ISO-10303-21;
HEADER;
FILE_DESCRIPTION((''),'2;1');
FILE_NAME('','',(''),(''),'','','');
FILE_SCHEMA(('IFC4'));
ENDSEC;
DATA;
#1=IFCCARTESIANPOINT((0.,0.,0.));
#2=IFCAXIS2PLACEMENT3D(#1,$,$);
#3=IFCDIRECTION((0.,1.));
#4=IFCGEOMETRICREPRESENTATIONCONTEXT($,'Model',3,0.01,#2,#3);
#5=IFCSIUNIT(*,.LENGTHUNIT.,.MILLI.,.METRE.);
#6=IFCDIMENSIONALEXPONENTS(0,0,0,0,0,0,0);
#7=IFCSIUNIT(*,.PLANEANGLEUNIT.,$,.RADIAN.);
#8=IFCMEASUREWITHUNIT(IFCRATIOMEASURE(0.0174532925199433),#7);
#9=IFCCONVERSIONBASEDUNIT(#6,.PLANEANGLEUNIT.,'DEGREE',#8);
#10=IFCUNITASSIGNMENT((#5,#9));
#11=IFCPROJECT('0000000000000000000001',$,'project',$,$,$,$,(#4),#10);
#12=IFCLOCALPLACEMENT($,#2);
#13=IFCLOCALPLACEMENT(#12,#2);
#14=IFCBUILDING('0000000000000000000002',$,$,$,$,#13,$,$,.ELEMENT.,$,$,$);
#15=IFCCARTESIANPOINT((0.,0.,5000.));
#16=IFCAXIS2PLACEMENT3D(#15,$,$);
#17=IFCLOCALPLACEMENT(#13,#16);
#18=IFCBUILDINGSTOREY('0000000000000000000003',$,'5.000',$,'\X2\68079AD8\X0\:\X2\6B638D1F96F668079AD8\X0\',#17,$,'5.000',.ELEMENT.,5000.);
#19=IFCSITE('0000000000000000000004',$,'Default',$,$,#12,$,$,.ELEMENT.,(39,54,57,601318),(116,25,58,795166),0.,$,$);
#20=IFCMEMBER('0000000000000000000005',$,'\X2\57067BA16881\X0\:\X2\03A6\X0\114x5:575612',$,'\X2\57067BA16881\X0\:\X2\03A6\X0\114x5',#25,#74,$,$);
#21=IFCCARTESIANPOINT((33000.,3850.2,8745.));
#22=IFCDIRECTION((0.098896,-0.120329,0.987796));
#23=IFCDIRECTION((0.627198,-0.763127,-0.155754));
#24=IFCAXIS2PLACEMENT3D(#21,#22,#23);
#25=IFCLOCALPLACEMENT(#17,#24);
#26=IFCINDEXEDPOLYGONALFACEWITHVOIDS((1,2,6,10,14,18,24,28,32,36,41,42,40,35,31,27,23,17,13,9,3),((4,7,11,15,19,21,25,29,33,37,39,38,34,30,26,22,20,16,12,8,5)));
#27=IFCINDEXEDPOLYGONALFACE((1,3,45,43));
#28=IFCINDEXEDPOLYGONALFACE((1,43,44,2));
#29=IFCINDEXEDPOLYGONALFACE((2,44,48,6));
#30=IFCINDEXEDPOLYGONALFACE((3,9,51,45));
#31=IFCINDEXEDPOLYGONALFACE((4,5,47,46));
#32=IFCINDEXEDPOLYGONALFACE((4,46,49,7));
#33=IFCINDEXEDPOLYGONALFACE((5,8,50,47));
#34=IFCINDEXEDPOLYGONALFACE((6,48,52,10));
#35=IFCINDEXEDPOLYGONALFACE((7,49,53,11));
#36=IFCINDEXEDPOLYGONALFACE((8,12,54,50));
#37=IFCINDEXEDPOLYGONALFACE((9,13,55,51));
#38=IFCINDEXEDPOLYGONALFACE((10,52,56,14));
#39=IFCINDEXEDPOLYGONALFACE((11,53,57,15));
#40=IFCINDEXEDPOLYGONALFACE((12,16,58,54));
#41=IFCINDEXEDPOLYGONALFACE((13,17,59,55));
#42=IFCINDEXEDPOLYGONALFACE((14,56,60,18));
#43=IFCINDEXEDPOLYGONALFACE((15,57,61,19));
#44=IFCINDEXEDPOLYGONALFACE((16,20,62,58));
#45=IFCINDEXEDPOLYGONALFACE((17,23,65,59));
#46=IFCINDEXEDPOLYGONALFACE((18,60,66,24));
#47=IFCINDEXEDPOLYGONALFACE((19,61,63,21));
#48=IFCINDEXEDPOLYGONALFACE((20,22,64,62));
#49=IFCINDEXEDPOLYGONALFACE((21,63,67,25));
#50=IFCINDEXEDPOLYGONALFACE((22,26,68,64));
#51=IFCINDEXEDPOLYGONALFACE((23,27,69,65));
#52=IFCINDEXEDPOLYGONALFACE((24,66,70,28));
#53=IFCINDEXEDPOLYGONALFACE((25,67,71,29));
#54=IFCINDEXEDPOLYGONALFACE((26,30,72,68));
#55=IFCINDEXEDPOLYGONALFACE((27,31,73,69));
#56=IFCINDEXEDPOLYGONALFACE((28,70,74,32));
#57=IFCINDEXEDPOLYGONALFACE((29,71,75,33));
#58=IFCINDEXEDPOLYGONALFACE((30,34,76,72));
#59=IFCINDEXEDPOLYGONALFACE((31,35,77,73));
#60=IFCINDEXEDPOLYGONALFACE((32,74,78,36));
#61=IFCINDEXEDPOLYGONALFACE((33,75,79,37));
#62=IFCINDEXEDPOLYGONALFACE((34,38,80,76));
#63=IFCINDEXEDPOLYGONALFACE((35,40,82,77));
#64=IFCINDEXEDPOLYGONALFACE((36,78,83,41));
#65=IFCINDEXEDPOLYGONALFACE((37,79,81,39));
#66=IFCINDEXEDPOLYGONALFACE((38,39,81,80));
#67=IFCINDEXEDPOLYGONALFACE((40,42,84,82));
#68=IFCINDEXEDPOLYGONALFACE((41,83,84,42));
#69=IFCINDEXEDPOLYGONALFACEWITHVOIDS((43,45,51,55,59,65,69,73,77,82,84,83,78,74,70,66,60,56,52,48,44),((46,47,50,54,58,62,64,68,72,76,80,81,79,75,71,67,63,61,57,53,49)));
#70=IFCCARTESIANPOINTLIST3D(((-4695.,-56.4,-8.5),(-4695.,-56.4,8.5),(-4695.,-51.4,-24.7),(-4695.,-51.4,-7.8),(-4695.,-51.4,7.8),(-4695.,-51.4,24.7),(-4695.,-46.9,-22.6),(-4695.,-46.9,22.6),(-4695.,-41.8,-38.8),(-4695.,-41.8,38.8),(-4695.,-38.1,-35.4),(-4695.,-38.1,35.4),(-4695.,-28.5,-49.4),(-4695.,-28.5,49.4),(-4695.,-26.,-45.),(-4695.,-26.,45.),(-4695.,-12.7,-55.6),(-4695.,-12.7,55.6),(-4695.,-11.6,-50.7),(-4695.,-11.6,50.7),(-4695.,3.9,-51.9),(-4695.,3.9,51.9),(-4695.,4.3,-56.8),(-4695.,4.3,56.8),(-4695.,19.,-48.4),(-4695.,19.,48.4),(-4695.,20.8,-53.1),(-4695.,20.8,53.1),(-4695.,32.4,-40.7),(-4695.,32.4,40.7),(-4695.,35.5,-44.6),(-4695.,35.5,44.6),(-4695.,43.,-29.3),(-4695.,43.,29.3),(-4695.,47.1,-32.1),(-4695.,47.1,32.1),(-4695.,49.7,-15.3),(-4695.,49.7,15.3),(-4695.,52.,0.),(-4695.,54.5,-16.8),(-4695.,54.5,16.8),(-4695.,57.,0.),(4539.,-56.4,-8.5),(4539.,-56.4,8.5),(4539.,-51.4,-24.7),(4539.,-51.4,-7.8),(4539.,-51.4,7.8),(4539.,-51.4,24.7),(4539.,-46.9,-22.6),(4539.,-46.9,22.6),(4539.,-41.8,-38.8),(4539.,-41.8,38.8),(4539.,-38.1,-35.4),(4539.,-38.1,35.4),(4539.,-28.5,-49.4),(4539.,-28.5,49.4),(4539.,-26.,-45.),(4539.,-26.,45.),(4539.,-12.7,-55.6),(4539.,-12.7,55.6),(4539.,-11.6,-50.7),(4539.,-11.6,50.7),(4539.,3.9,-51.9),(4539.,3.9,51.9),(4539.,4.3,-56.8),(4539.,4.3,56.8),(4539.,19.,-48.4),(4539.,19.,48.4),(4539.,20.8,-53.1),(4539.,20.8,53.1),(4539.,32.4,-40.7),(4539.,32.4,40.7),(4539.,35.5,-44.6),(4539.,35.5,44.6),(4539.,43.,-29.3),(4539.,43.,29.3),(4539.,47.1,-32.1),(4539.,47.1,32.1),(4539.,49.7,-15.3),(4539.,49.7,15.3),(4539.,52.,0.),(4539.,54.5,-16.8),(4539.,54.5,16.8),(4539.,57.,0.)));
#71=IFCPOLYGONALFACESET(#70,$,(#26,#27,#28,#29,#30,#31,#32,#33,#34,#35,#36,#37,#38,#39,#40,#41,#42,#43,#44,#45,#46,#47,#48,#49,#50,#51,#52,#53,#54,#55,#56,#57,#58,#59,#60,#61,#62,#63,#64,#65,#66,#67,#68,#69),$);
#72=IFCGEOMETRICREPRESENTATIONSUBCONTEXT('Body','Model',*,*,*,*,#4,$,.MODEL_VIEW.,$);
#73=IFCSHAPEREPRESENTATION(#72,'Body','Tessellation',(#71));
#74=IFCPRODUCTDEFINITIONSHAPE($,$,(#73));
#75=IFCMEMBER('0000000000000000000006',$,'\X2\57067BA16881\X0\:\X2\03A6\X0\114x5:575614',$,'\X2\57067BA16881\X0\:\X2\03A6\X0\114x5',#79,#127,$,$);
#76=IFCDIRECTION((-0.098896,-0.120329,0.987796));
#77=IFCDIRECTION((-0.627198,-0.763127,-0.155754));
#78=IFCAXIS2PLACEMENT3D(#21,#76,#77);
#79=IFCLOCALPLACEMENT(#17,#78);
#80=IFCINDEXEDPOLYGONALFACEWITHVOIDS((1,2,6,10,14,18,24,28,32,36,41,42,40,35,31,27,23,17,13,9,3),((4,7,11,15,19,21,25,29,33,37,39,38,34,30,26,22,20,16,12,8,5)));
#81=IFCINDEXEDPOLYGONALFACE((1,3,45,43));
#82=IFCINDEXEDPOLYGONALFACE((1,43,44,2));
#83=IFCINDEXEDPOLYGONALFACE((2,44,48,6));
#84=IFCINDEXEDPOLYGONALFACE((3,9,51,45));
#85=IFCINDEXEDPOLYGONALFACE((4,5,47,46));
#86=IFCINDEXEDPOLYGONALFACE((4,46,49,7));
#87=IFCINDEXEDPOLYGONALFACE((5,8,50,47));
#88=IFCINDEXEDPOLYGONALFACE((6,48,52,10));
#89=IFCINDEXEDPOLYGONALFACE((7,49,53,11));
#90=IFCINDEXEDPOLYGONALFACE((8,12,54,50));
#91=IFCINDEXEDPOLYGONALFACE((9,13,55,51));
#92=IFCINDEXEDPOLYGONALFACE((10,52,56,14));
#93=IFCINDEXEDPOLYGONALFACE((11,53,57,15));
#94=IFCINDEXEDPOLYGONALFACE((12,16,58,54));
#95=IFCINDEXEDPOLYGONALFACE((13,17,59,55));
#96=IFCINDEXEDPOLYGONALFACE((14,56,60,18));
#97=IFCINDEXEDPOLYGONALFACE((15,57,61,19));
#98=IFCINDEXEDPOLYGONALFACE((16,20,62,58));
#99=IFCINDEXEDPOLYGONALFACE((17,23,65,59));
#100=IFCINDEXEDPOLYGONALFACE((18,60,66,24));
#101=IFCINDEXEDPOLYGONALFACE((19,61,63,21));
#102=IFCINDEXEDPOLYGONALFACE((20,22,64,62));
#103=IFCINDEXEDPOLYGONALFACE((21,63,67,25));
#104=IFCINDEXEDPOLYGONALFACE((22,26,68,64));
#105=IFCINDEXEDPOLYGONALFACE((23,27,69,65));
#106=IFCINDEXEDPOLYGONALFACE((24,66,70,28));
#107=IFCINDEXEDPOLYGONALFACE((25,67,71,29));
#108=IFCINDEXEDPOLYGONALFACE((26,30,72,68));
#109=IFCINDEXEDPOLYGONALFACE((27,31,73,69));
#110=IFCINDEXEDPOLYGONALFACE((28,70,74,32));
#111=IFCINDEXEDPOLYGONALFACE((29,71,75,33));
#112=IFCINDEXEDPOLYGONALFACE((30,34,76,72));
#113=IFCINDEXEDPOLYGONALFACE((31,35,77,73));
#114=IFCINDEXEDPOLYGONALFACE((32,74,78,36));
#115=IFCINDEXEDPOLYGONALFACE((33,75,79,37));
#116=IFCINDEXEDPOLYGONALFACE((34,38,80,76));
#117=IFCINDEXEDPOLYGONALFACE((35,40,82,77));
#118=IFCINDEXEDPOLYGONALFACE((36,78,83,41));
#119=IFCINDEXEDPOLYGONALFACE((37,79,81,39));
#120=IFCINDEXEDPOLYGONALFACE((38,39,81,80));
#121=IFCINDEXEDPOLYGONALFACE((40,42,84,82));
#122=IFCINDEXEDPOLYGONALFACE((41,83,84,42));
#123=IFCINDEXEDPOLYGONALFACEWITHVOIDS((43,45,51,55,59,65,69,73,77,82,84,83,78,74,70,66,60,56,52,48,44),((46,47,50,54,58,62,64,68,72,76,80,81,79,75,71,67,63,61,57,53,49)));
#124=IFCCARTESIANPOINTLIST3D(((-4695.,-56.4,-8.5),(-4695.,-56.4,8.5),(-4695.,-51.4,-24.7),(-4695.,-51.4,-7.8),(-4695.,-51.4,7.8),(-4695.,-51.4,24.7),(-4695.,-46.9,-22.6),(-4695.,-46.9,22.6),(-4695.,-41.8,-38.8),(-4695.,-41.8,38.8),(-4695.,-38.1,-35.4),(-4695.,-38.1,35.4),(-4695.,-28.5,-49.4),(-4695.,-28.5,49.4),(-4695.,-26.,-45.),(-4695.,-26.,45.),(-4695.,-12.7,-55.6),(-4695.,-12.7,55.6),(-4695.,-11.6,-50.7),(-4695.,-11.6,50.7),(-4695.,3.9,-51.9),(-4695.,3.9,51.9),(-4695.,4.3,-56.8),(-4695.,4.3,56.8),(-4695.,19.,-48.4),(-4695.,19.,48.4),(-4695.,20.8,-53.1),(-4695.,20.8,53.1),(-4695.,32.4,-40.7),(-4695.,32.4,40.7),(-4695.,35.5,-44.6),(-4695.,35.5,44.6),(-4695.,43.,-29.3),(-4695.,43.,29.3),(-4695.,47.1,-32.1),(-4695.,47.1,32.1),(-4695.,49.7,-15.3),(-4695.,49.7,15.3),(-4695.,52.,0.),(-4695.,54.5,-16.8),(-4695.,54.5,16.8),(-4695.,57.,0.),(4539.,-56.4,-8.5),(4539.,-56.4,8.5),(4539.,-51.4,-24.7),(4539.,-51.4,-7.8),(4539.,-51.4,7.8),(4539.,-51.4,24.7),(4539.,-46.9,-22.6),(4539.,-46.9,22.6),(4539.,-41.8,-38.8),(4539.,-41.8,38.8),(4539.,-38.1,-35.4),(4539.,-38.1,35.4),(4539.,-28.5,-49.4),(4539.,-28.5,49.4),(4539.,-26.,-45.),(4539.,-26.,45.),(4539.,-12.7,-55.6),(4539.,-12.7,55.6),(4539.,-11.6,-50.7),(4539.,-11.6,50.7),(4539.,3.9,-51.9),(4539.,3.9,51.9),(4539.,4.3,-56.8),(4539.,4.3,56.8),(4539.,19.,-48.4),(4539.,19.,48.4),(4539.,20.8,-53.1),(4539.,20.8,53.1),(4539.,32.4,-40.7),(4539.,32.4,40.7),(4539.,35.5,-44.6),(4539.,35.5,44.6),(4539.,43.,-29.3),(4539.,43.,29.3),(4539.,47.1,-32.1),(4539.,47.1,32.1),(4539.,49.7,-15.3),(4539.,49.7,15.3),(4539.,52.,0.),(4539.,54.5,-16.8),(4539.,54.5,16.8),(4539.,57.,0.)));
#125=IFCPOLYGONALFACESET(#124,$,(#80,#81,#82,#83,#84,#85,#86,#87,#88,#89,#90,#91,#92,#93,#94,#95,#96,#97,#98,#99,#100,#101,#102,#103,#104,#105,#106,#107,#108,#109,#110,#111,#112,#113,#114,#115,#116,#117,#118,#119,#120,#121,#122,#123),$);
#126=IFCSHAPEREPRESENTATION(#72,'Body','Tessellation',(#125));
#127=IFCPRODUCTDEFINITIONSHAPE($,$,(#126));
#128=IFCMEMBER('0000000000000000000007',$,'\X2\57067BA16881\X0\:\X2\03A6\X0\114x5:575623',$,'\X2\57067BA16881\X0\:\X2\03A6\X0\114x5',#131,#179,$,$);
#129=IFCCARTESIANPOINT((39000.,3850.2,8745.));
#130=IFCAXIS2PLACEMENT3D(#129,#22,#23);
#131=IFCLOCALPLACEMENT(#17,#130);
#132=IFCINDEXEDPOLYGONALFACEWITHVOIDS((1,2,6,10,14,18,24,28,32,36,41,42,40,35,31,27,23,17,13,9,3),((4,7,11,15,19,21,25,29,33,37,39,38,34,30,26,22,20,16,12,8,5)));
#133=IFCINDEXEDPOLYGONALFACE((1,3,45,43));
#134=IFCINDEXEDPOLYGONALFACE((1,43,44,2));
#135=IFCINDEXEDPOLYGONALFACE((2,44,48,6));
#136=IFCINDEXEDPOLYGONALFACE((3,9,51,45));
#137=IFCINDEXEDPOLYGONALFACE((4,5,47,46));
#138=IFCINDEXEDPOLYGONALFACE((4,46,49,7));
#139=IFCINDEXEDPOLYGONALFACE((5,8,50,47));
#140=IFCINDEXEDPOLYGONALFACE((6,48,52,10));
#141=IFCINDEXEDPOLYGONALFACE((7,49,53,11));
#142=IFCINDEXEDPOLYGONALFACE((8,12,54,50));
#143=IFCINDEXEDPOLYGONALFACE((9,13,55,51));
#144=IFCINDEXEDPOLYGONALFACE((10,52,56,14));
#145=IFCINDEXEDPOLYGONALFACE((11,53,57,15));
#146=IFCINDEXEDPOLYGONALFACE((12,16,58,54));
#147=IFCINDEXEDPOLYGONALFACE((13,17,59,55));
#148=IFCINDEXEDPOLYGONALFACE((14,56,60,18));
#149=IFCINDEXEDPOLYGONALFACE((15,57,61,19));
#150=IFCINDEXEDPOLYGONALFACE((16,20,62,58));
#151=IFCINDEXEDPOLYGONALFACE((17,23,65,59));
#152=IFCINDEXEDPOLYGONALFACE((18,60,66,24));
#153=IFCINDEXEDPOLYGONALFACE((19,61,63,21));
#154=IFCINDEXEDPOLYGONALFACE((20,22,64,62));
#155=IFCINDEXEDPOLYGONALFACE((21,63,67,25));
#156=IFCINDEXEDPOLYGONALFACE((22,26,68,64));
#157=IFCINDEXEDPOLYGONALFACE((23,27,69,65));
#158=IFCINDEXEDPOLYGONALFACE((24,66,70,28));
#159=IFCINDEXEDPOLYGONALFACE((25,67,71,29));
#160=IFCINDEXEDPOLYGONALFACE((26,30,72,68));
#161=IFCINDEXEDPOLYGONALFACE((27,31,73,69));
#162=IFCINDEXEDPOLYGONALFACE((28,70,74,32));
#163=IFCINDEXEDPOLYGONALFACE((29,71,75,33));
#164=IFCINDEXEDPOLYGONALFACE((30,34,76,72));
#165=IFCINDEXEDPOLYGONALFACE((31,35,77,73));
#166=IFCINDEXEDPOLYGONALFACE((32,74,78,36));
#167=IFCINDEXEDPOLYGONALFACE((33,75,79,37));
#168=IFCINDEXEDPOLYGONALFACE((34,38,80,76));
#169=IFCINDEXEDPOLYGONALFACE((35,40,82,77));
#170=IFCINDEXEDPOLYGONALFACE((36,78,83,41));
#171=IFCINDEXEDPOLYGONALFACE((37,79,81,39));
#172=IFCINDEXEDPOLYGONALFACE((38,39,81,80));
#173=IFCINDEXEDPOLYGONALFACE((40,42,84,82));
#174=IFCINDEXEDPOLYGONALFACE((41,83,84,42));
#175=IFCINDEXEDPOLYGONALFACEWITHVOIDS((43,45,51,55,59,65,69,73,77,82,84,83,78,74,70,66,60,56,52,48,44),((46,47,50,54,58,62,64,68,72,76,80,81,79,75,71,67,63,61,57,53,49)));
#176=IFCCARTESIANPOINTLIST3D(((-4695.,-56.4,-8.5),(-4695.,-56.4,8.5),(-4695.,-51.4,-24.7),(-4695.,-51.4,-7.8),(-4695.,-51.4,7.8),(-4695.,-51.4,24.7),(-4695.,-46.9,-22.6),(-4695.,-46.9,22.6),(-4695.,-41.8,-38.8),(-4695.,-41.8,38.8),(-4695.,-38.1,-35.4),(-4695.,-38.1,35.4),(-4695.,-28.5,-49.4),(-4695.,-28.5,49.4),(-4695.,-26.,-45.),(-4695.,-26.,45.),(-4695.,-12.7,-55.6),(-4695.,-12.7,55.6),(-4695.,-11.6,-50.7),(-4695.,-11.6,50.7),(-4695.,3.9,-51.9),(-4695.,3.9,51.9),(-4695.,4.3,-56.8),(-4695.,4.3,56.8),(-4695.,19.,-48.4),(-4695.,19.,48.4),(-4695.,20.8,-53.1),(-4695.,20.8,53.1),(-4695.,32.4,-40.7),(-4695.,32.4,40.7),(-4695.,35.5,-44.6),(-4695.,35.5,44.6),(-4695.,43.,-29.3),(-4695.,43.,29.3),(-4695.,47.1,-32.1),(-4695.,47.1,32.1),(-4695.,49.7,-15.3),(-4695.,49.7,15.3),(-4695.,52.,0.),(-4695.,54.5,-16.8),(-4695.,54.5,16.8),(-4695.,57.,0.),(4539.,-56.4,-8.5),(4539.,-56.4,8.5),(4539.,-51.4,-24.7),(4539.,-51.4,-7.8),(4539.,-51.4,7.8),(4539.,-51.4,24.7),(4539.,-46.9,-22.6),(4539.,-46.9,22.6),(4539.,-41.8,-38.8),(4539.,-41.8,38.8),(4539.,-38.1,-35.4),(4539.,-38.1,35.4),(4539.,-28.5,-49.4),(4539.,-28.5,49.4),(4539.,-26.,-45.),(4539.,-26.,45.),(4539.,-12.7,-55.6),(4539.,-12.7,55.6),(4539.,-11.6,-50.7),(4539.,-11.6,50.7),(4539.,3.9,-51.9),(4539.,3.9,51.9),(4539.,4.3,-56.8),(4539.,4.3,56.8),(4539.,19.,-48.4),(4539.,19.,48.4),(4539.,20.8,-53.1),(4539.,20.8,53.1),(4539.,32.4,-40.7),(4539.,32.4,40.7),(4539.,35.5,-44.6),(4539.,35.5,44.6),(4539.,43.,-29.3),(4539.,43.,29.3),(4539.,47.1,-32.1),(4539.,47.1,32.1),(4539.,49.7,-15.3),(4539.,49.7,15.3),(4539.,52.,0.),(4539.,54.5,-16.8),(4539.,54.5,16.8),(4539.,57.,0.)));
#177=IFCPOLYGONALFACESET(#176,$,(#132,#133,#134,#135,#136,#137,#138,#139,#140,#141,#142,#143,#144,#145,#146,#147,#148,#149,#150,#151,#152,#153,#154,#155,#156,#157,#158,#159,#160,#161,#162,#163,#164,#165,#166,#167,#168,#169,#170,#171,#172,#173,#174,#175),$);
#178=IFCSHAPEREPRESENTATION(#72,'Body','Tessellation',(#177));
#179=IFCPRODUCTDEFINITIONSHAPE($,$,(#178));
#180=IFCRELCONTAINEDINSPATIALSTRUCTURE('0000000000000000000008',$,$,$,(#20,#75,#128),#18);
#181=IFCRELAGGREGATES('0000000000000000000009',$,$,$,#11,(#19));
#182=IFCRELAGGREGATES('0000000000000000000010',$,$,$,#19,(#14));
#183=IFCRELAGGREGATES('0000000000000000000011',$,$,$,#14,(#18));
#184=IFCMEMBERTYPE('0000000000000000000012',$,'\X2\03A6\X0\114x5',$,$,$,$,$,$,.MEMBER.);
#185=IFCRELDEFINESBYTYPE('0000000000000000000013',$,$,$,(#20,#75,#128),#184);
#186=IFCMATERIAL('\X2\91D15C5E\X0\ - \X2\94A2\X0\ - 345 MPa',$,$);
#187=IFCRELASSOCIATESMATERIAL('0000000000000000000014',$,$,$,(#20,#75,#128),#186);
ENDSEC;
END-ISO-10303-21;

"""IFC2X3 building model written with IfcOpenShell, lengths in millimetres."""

from ifc_helpers import new_model, entity, si_unit, converted_unit, direction, frame, frame_2d, origin, place, context, subcontext, project, spatial, hollow_circle, extrude, source, transform, mapped, material, type_object, type_shapes, element, save


model = new_model("IFC2X3")

# Units and contexts
model_context = context("Model", 3, precision=0.01, world=origin(), true_north=direction((0.0, 1.0)))
body_context = subcontext(model_context, "Body", "Model", "MODEL_VIEW")
ifc_project = project(units=[si_unit("LENGTHUNIT", "METRE", prefix="MILLI"), converted_unit("PLANEANGLEUNIT", "DEGREE", entity("IfcRatioMeasure", 0.0174532925199433), si_unit("PLANEANGLEUNIT", "RADIAN"), dimensions=[0, 0, 0, 0, 0, 0, 0])], contexts=[model_context])

# Site, building, storey
site_placement = place(None, origin())
site = spatial("IfcSite", under=ifc_project, at=site_placement, Name="Default", CompositionType="ELEMENT", RefLatitude=(39, 54, 57, 601318), RefLongitude=(116, 25, 58, 795166), RefElevation=0.0)
building_placement = place(site_placement, origin())
building = spatial("IfcBuilding", under=site, at=building_placement, CompositionType="ELEMENT")
storey_placement = place(building_placement, frame((0.0, 0.0, 5000.0)))
storey = spatial("IfcBuildingStorey", under=building, at=storey_placement, Name="5.000", ObjectType="标高:正负零标高", LongName="5.000", CompositionType="ELEMENT", Elevation=5000.0)

# Members
ifc_material_1 = material(Name="金属 - 钢 - 345 MPa")
member_type_1 = type_object("IfcMemberType", Name="Φ114x5", PredefinedType="MEMBER")
shared_shape_1 = source(origin(), body_context, "Body", "SweptSolid", [
    extrude(hollow_circle(Radius=57.0, WallThickness=5.0, at=frame_2d((0.0, 0.0), x_axis=(1.0, 0.0))), frame((-4695.0, 0.0, 0.0), z_axis=(1.0, 0.0, 0.0), x_axis=(0.0, 1.0, 0.0)), (0.0, 0.0, 1.0), 9234.0),
])
type_shapes(member_type_1, [shared_shape_1])
for number, where, z_axis, x_axis, name in (
    (1, (33000.0, 3850.2, 8745.0), (0.098896, -0.120329, 0.987796), (0.627198, -0.763127, -0.155754), "圆管梁:Φ114x5:575612"),
    (2, (33000.0, 3850.2, 8745.0), (-0.098896, -0.120329, 0.987796), (-0.627198, -0.763127, -0.155754), "圆管梁:Φ114x5:575614"),
    (3, (39000.0, 3850.2, 8745.0), (0.098896, -0.120329, 0.987796), (0.627198, -0.763127, -0.155754), "圆管梁:Φ114x5:575623"),
):
    element("IfcMember", number, at=place(storey_placement, frame(where, z_axis=z_axis, x_axis=x_axis)), inside=storey, type_object=member_type_1, material=ifc_material_1, Name=name, ObjectType="圆管梁:Φ114x5", context=body_context, shape_type="MappedRepresentation", body=[
        mapped(shared_shape_1, transform((0.0, 0.0, 0.0), scale=1.0)),
    ])

save(model, "model.ifc")
